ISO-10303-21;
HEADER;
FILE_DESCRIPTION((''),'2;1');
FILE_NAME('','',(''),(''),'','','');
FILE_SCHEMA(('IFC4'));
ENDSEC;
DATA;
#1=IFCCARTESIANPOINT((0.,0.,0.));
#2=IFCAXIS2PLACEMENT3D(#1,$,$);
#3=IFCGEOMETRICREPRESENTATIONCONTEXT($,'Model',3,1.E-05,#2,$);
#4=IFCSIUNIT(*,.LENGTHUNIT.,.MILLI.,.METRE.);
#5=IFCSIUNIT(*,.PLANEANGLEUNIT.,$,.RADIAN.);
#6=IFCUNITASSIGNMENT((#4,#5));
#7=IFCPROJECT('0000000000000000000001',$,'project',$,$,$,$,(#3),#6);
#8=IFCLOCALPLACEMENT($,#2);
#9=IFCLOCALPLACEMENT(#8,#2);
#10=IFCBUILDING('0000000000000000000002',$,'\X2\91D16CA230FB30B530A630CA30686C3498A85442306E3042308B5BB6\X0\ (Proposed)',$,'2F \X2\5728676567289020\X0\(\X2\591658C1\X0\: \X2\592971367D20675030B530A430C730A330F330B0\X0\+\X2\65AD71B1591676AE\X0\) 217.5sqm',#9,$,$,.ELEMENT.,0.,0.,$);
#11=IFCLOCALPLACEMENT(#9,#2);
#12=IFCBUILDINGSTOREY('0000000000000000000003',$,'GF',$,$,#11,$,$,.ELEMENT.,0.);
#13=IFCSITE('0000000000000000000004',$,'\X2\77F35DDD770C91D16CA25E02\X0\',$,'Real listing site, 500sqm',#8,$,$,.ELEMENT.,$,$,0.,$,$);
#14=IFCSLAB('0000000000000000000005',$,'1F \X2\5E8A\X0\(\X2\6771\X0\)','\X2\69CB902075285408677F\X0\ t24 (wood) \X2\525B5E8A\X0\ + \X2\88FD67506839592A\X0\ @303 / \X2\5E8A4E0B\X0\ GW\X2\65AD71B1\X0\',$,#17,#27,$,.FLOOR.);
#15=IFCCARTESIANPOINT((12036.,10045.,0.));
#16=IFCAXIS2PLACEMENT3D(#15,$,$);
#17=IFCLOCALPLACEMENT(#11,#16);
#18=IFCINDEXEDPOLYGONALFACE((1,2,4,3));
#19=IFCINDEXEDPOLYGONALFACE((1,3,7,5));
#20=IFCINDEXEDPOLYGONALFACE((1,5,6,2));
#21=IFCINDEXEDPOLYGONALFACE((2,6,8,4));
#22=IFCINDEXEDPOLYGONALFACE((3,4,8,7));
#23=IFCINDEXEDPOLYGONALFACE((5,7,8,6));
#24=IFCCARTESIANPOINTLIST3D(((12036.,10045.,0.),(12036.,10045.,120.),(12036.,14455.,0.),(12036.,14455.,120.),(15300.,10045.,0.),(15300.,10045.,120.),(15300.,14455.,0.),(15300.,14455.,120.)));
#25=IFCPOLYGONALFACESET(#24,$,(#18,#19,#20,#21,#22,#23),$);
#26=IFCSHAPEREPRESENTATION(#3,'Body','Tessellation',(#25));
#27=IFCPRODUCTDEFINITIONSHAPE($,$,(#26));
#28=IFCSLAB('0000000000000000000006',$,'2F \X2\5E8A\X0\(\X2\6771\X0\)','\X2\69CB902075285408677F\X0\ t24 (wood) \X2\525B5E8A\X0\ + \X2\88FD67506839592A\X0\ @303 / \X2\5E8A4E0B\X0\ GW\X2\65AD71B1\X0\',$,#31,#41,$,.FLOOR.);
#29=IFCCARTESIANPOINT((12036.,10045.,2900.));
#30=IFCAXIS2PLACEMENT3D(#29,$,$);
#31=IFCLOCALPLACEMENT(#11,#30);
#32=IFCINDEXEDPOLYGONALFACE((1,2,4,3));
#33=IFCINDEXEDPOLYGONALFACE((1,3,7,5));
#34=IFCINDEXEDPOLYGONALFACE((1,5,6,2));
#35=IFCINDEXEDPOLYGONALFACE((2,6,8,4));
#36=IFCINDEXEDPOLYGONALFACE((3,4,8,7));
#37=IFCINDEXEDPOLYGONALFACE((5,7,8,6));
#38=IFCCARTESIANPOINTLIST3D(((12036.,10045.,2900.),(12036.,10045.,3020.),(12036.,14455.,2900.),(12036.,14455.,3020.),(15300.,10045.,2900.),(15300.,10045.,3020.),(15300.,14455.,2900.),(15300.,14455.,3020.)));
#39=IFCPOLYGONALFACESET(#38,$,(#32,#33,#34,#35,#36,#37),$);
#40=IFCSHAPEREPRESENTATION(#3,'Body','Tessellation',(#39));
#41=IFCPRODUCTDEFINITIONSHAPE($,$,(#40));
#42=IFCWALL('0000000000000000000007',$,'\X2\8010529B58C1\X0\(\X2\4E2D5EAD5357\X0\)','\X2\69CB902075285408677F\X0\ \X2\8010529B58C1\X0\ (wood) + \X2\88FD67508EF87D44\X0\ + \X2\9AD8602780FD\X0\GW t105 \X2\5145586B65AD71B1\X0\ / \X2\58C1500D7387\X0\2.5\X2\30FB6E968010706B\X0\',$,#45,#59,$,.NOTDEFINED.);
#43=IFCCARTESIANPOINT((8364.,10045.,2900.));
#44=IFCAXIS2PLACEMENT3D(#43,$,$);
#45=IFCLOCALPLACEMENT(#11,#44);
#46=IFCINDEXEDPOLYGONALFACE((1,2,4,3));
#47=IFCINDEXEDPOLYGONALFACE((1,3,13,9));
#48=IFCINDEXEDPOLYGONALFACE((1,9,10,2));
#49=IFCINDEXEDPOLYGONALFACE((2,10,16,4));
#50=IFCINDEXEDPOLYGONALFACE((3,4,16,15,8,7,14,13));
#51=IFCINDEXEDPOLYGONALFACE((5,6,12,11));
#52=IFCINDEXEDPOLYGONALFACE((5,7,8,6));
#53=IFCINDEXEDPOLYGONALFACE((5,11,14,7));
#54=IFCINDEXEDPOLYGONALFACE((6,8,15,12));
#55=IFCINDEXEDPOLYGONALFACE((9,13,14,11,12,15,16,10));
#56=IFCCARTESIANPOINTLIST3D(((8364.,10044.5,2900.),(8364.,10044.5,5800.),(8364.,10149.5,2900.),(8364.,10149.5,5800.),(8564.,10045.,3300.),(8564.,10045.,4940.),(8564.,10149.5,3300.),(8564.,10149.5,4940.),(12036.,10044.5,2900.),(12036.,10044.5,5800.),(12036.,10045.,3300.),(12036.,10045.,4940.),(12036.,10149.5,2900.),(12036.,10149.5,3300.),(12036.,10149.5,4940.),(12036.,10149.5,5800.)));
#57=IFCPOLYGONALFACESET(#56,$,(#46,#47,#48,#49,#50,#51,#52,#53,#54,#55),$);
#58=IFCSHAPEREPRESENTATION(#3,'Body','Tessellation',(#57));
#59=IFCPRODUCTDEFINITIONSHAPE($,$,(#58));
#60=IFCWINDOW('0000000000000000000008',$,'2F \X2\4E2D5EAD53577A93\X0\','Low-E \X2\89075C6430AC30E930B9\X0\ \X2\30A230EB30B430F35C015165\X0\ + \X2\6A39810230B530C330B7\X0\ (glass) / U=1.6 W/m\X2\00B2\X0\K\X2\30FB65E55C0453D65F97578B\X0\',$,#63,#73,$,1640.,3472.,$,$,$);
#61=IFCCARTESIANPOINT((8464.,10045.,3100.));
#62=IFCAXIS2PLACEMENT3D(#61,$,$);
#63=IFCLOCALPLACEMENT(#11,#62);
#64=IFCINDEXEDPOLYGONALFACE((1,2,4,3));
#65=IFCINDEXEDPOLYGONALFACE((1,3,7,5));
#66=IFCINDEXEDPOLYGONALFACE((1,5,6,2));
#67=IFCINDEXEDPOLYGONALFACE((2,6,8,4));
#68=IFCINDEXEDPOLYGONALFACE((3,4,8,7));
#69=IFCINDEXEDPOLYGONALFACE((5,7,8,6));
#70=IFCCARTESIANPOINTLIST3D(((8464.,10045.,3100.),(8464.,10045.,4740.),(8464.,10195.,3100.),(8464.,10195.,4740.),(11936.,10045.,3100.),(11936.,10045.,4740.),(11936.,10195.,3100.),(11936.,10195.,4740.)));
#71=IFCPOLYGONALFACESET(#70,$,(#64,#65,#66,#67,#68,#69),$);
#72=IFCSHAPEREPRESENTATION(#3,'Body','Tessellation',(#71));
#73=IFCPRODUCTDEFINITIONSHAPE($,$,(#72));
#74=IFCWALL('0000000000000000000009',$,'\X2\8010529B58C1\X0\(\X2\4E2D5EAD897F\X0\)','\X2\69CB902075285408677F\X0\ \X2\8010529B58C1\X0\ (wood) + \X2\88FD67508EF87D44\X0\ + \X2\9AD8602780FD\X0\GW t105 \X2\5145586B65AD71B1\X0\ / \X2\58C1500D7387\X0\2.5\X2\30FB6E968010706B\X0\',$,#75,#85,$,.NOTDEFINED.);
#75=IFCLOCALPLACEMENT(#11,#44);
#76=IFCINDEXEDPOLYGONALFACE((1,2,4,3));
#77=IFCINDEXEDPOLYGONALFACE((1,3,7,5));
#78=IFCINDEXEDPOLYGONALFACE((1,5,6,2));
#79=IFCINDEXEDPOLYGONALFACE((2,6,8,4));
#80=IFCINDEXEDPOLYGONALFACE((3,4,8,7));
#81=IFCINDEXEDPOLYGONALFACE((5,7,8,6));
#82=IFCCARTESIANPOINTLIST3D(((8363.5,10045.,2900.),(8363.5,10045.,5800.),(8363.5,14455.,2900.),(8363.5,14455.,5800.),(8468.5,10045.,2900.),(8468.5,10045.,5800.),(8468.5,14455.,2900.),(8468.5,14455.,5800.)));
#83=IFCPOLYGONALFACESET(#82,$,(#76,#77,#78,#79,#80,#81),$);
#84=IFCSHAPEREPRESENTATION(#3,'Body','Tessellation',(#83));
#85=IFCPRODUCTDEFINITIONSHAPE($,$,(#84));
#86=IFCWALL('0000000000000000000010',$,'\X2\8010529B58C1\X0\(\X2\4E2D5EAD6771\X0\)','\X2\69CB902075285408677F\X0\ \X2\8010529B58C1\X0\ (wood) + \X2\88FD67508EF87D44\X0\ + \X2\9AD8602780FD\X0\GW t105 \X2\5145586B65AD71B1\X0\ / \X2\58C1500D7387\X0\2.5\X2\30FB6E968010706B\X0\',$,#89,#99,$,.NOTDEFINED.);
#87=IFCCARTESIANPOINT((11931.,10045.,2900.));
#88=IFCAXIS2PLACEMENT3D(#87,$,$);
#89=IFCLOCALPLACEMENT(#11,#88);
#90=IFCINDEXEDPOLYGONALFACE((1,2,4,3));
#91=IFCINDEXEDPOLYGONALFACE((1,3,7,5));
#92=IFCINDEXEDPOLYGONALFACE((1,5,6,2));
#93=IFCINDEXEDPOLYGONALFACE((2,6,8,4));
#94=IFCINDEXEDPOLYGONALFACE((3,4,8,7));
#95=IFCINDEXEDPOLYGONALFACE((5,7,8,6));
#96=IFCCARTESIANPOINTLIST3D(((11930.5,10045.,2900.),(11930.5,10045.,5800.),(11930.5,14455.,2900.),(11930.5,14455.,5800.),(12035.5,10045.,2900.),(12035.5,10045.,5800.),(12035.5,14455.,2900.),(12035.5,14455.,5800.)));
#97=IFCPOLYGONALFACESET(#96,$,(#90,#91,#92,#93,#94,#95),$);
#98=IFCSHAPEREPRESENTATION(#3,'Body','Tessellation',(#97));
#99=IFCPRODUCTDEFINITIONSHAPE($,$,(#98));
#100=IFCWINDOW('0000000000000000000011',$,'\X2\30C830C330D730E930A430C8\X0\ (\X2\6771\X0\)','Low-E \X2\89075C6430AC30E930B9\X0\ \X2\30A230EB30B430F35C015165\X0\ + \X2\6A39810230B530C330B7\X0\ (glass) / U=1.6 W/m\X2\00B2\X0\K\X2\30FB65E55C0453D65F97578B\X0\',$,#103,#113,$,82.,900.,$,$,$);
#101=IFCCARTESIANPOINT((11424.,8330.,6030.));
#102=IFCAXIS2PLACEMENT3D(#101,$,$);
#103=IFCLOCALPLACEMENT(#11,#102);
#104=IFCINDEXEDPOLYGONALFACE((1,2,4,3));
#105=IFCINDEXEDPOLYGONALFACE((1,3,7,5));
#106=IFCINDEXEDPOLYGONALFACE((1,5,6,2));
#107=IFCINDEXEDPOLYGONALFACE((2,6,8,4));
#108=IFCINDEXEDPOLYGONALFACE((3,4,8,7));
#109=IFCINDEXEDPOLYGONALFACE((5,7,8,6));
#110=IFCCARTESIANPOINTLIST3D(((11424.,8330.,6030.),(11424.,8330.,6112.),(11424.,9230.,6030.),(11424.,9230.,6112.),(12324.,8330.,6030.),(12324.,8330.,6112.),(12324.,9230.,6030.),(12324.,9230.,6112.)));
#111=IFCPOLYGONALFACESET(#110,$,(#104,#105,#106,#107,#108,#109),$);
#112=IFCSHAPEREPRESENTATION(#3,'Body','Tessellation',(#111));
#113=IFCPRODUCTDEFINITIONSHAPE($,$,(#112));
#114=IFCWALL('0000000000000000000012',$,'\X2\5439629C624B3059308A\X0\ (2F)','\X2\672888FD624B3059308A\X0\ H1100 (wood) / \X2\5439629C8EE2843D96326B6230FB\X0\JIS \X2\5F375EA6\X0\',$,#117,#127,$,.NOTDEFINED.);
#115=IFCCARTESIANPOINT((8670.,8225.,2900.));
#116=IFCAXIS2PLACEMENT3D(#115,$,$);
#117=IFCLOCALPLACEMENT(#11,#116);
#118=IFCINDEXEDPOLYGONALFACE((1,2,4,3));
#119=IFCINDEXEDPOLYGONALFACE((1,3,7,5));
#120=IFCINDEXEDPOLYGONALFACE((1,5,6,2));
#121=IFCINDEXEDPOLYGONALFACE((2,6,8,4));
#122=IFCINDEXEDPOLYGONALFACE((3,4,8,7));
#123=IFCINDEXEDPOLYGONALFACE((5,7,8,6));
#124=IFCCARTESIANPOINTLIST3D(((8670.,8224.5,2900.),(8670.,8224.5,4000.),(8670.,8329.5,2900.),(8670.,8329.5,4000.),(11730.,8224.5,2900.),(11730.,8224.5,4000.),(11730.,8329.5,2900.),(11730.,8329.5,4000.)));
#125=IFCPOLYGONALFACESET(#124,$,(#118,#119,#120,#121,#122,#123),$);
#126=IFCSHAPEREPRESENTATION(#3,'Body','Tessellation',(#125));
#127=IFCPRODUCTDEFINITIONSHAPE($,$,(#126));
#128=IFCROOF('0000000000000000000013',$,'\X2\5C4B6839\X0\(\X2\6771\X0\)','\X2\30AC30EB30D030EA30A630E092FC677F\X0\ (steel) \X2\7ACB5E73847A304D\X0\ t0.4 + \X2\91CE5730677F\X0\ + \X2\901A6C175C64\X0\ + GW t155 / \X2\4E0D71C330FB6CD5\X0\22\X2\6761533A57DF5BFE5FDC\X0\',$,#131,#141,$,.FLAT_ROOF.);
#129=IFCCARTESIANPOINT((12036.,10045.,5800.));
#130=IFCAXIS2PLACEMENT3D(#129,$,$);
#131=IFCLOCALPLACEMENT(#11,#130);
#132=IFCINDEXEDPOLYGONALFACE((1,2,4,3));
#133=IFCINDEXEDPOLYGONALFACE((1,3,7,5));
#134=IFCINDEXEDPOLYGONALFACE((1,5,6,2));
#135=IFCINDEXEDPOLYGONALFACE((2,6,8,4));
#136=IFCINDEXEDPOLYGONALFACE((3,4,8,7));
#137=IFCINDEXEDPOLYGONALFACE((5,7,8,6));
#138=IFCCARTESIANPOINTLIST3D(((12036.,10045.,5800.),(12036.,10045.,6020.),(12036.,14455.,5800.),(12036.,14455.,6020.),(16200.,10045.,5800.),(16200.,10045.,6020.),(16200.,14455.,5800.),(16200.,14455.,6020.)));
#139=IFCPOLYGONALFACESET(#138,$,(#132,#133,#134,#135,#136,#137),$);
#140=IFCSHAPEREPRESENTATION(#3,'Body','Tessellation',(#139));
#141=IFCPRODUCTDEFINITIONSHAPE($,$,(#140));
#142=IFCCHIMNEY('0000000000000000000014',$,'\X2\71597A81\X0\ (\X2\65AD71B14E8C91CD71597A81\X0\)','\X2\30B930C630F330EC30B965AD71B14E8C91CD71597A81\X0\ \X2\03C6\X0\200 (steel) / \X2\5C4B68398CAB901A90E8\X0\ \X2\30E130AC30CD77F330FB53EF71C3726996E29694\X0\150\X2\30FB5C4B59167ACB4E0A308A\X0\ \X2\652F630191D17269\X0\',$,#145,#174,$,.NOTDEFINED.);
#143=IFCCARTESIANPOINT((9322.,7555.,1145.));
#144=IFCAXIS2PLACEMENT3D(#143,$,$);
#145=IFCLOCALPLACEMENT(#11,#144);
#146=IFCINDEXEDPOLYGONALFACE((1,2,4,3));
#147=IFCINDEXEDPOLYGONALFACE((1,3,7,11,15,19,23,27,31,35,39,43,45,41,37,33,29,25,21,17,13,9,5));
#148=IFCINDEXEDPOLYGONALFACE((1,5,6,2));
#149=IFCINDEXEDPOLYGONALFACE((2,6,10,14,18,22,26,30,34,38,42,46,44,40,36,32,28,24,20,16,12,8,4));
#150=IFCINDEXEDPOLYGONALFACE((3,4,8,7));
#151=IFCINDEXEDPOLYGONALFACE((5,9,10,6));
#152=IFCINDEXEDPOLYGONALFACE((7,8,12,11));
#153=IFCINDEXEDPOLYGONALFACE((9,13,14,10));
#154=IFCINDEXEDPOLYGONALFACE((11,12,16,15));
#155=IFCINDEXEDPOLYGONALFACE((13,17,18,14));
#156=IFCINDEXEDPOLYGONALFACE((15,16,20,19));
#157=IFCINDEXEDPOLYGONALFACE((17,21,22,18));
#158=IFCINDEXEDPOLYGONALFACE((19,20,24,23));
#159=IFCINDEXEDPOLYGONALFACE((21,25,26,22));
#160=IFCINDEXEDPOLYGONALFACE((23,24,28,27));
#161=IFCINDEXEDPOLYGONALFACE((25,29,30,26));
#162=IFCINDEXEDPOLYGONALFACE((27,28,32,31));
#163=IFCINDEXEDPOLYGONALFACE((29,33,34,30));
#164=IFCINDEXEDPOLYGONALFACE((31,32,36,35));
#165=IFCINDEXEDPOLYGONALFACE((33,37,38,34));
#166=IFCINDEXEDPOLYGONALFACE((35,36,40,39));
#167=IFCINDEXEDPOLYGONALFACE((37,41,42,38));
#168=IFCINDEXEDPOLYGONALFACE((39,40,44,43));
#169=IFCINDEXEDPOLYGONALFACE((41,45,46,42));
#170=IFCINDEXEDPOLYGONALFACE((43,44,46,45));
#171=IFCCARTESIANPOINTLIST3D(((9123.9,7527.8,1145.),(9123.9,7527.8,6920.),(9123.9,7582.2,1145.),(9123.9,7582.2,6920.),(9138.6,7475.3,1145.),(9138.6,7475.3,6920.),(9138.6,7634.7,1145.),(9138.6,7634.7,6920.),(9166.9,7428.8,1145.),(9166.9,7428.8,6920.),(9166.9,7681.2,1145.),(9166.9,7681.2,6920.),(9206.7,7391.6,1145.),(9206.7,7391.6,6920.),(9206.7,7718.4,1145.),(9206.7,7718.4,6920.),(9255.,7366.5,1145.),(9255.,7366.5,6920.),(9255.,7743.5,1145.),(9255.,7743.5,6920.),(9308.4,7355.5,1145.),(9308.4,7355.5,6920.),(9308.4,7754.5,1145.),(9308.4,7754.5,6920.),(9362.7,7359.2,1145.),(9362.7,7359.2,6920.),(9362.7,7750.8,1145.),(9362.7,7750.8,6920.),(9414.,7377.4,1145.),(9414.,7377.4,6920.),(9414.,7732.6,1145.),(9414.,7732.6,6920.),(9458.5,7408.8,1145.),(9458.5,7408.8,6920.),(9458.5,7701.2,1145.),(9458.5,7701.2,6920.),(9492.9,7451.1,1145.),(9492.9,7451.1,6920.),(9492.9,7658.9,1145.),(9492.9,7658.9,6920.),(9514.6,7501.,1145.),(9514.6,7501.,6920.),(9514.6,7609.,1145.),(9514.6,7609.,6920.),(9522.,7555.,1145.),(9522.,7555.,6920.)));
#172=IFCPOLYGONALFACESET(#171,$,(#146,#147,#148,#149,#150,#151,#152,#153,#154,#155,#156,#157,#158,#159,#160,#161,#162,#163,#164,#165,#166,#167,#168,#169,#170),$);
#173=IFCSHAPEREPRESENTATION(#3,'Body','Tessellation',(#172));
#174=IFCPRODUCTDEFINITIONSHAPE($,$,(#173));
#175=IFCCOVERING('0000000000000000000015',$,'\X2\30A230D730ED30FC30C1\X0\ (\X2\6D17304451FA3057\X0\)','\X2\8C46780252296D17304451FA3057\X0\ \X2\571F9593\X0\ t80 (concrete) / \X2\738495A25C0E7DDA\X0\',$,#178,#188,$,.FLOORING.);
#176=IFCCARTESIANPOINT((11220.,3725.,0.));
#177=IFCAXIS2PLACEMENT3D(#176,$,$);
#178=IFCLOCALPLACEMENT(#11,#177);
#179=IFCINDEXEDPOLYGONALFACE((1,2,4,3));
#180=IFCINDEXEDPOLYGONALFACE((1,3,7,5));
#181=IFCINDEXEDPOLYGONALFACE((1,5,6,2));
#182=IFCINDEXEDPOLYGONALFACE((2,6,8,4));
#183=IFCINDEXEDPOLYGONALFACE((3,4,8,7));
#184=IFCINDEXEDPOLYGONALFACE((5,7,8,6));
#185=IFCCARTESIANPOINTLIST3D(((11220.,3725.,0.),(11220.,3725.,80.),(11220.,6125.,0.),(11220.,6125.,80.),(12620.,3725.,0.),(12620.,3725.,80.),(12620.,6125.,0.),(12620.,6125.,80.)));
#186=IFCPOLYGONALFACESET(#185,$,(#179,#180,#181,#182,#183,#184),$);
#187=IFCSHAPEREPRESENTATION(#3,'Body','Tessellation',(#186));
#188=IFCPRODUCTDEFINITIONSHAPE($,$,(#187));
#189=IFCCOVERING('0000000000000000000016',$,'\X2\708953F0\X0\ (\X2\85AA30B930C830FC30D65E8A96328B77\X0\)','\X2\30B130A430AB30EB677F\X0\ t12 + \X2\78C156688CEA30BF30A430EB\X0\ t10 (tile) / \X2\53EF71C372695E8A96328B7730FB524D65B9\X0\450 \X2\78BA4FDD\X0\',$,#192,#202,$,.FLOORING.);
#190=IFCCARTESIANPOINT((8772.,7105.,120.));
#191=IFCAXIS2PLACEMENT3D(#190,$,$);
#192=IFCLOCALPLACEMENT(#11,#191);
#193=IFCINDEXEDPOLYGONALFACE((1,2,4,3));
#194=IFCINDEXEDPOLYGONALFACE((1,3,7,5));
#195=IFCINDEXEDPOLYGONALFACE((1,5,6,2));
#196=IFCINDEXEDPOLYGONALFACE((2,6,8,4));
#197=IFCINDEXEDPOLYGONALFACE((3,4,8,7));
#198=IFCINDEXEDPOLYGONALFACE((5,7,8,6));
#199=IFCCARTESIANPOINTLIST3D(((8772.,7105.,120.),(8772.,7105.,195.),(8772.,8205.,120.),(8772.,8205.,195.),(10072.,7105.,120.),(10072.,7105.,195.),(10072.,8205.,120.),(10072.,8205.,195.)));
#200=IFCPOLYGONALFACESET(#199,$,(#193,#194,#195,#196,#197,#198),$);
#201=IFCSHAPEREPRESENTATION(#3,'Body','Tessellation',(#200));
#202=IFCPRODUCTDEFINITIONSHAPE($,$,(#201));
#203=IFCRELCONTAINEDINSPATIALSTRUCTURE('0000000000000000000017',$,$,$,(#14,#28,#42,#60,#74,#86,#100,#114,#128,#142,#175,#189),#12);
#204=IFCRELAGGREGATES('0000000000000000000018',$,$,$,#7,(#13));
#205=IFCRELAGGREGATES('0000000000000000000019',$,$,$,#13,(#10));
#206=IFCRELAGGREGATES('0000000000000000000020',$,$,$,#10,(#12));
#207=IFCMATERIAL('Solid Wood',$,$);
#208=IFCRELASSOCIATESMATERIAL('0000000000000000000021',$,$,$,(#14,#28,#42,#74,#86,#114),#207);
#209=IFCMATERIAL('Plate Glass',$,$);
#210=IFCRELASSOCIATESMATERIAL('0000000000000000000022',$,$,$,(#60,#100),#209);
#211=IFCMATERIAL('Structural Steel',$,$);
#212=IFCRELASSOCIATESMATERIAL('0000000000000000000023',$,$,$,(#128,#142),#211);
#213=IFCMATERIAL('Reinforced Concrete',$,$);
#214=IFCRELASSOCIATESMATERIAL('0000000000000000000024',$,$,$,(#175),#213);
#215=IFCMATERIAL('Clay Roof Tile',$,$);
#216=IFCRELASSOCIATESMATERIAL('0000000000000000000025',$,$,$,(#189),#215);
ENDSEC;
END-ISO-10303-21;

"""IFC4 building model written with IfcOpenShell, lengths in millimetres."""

from ifc_helpers import new_model, si_unit, frame, frame_2d, origin, origin_2d, place, context, project, spatial, rectangle, circle, extrude, material, element, fill, save


model = new_model("IFC4")

# Units and contexts
model_context = context("Model", 3, precision=1e-05, world=origin())
ifc_project = project(units=[si_unit("LENGTHUNIT", "METRE", prefix="MILLI"), si_unit("PLANEANGLEUNIT", "RADIAN")], contexts=[model_context])

# Site, building, storey
site_placement = place(None, origin())
site = spatial("IfcSite", under=ifc_project, at=site_placement, Name="石川県金沢市", ObjectType="Real listing site, 500sqm", CompositionType="ELEMENT", RefElevation=0.0)
building_placement = place(site_placement, origin())
building = spatial("IfcBuilding", under=site, at=building_placement, Name="金沢・サウナと水風呂のある家 (Proposed)", ObjectType="2F 在来木造(外壁: 天然素材サイディング+断熱外皮) 217.5sqm", CompositionType="ELEMENT", ElevationOfRefHeight=0.0, ElevationOfTerrain=0.0)
storey_placement = place(building_placement, origin())
storey = spatial("IfcBuildingStorey", under=building, at=storey_placement, Name="GF", CompositionType="ELEMENT", Elevation=0.0)

# Shared definitions
ifc_material_1 = material(Name="Solid Wood")

# Slabs
slab_1_placement = place(storey_placement, frame((12036.0, 10045.0, 0.0)))
element("IfcSlab", 1, at=slab_1_placement, inside=storey, material=ifc_material_1, Name="1F 床(東)", Description="構造用合板 t24 (wood) 剛床 + 製材根太 @303 / 床下 GW断熱", PredefinedType="FLOOR", context=model_context, shape_type="SweptSolid", body=[
    extrude(rectangle(XDim=3264.0, YDim=4410.0, at=frame_2d((1632.0, 2205.0))), frame((12036.0, 10045.0, 0.0)), (0.0, 0.0, 1.0), 120.0),
])
slab_2_placement = place(storey_placement, frame((12036.0, 10045.0, 2900.0)))
element("IfcSlab", 2, at=slab_2_placement, inside=storey, material=ifc_material_1, Name="2F 床(東)", Description="構造用合板 t24 (wood) 剛床 + 製材根太 @303 / 床下 GW断熱", PredefinedType="FLOOR", context=model_context, shape_type="SweptSolid", body=[
    extrude(rectangle(XDim=3264.0, YDim=4410.0, at=frame_2d((1632.0, 2205.0))), frame((12036.0, 10045.0, 2900.0)), (0.0, 0.0, 1.0), 120.0),
])

# Wall, opening, window
wall_1_placement = place(storey_placement, frame((8364.0, 10045.0, 2900.0)))
wall_1 = element("IfcWall", 3, at=wall_1_placement, inside=storey, material=ifc_material_1, Name="耐力壁(中庭南)", Description="構造用合板 耐力壁 (wood) + 製材軸組 + 高性能GW t105 充填断熱 / 壁倍率2.5・準耐火", PredefinedType="NOTDEFINED", context=model_context, shape_type="SweptSolid", body=[
    extrude(rectangle(XDim=3672.0, YDim=105.0, at=frame_2d((1836.0, 52.0))), frame((8364.0, 10045.0, 2900.0)), (0.0, 0.0, 1.0), 2900.0),
])
opening_placement = place(storey_placement, frame((8464.0, 10045.0, 3100.0)))
opening = element("IfcOpeningElement", 4, at=opening_placement, cuts=wall_1, PredefinedType="NOTDEFINED", context=model_context, shape_type="SweptSolid", body=[
    extrude(rectangle(XDim=3472.0, YDim=150.0, at=frame_2d((1736.0, 75.0))), frame((8464.0, 10045.0, 3100.0)), (0.0, 0.0, 1.0), 1640.0),
])
ifc_material_2 = material(Name="Plate Glass")
window_1_placement = place(storey_placement, frame((8464.0, 10045.0, 3100.0)))
window_1 = element("IfcWindow", 5, at=window_1_placement, inside=storey, material=ifc_material_2, Name="2F 中庭南窓", Description="Low-E 複層ガラス アルゴン封入 + 樹脂サッシ (glass) / U=1.6 W/m²K・日射取得型", OverallHeight=1640.0, OverallWidth=3472.0, context=model_context, shape_type="SweptSolid", body=[
    extrude(rectangle(XDim=3472.0, YDim=150.0, at=frame_2d((1736.0, 75.0))), frame((8464.0, 10045.0, 3100.0)), (0.0, 0.0, 1.0), 1640.0),
])
fill(opening, window_1)

# Walls
wall_2_placement = place(storey_placement, frame((8364.0, 10045.0, 2900.0)))
element("IfcWall", 6, at=wall_2_placement, inside=storey, material=ifc_material_1, Name="耐力壁(中庭西)", Description="構造用合板 耐力壁 (wood) + 製材軸組 + 高性能GW t105 充填断熱 / 壁倍率2.5・準耐火", PredefinedType="NOTDEFINED", context=model_context, shape_type="SweptSolid", body=[
    extrude(rectangle(XDim=105.0, YDim=4410.0, at=frame_2d((52.0, 2205.0))), frame((8364.0, 10045.0, 2900.0)), (0.0, 0.0, 1.0), 2900.0),
])
wall_3_placement = place(storey_placement, frame((11931.0, 10045.0, 2900.0)))
element("IfcWall", 7, at=wall_3_placement, inside=storey, material=ifc_material_1, Name="耐力壁(中庭東)", Description="構造用合板 耐力壁 (wood) + 製材軸組 + 高性能GW t105 充填断熱 / 壁倍率2.5・準耐火", PredefinedType="NOTDEFINED", context=model_context, shape_type="SweptSolid", body=[
    extrude(rectangle(XDim=105.0, YDim=4410.0, at=frame_2d((52.0, 2205.0))), frame((11931.0, 10045.0, 2900.0)), (0.0, 0.0, 1.0), 2900.0),
])

# Window
window_2_placement = place(storey_placement, frame((11424.0, 8330.0, 6030.0)))
element("IfcWindow", 8, at=window_2_placement, inside=storey, material=ifc_material_2, Name="トップライト (東)", Description="Low-E 複層ガラス アルゴン封入 + 樹脂サッシ (glass) / U=1.6 W/m²K・日射取得型", OverallHeight=82.0, OverallWidth=900.0, context=model_context, shape_type="SweptSolid", body=[
    extrude(rectangle(XDim=900.0, YDim=900.0, at=frame_2d((450.0, 450.0))), frame((11424.0, 8330.0, 6030.0)), (0.0, 0.0, 1.0), 82.0),
])

# Wall
wall_4_placement = place(storey_placement, frame((8670.0, 8225.0, 2900.0)))
element("IfcWall", 9, at=wall_4_placement, inside=storey, material=ifc_material_1, Name="吹抜手すり (2F)", Description="木製手すり H1100 (wood) / 吹抜転落防止・JIS 強度", PredefinedType="NOTDEFINED", context=model_context, shape_type="SweptSolid", body=[
    extrude(rectangle(XDim=3060.0, YDim=105.0, at=frame_2d((1530.0, 52.0))), frame((8670.0, 8225.0, 2900.0)), (0.0, 0.0, 1.0), 1100.0),
])

# Roof
ifc_material_3 = material(Name="Structural Steel")
for number, where, name in (
    (10, (12036.0, 10045.0, 5800.0), "屋根(東)"),
):
    element("IfcRoof", number, at=place(storey_placement, frame(where)), inside=storey, material=ifc_material_3, Name=name, Description="ガルバリウム鋼板 (steel) 立平葺き t0.4 + 野地板 + 通気層 + GW t155 / 不燃・法22条区域対応", PredefinedType="FLAT_ROOF", context=model_context, shape_type="SweptSolid", body=[
        extrude(rectangle(XDim=4164.0, YDim=4410.0, at=frame_2d((2082.0, 2205.0))), frame((12036.0, 10045.0, 5800.0)), (0.0, 0.0, 1.0), 220.0),
    ])

# Chimney
chimney_placement = place(storey_placement, frame((9322.0, 7555.0, 1145.0)))
element("IfcChimney", 11, at=chimney_placement, inside=storey, material=ifc_material_3, Name="煙突 (断熱二重煙突)", Description="ステンレス断熱二重煙突 φ200 (steel) / 屋根貫通部 メガネ石・可燃物離隔150・屋外立上り 支持金物", PredefinedType="NOTDEFINED", context=model_context, shape_type="SweptSolid", body=[
    extrude(circle(Radius=200.0, at=origin_2d()), frame((9322.0, 7555.0, 1145.0)), (0.0, 0.0, 1.0), 5775.0),
])

# Coverings
ifc_material_4 = material(Name="Reinforced Concrete")
covering_1_placement = place(storey_placement, frame((11220.0, 3725.0, 0.0)))
element("IfcCovering", 12, at=covering_1_placement, inside=storey, material=ifc_material_4, Name="アプローチ (洗い出し)", Description="豆砂利洗い出し 土間 t80 (concrete) / 玄関導線", PredefinedType="FLOORING", context=model_context, shape_type="SweptSolid", body=[
    extrude(rectangle(XDim=1400.0, YDim=2400.0, at=frame_2d((700.0, 1200.0))), frame((11220.0, 3725.0, 0.0)), (0.0, 0.0, 1.0), 80.0),
])
ifc_material_5 = material(Name="Clay Roof Tile")
covering_2_placement = place(storey_placement, frame((8772.0, 7105.0, 120.0)))
element("IfcCovering", 13, at=covering_2_placement, inside=storey, material=ifc_material_5, Name="炉台 (薪ストーブ床防護)", Description="ケイカル板 t12 + 磁器質タイル t10 (tile) / 可燃物床防護・前方450 確保", PredefinedType="FLOORING", context=model_context, shape_type="SweptSolid", body=[
    extrude(rectangle(XDim=1300.0, YDim=1100.0, at=frame_2d((650.0, 550.0))), frame((8772.0, 7105.0, 120.0)), (0.0, 0.0, 1.0), 75.0),
])

save(model, "model.ifc")
